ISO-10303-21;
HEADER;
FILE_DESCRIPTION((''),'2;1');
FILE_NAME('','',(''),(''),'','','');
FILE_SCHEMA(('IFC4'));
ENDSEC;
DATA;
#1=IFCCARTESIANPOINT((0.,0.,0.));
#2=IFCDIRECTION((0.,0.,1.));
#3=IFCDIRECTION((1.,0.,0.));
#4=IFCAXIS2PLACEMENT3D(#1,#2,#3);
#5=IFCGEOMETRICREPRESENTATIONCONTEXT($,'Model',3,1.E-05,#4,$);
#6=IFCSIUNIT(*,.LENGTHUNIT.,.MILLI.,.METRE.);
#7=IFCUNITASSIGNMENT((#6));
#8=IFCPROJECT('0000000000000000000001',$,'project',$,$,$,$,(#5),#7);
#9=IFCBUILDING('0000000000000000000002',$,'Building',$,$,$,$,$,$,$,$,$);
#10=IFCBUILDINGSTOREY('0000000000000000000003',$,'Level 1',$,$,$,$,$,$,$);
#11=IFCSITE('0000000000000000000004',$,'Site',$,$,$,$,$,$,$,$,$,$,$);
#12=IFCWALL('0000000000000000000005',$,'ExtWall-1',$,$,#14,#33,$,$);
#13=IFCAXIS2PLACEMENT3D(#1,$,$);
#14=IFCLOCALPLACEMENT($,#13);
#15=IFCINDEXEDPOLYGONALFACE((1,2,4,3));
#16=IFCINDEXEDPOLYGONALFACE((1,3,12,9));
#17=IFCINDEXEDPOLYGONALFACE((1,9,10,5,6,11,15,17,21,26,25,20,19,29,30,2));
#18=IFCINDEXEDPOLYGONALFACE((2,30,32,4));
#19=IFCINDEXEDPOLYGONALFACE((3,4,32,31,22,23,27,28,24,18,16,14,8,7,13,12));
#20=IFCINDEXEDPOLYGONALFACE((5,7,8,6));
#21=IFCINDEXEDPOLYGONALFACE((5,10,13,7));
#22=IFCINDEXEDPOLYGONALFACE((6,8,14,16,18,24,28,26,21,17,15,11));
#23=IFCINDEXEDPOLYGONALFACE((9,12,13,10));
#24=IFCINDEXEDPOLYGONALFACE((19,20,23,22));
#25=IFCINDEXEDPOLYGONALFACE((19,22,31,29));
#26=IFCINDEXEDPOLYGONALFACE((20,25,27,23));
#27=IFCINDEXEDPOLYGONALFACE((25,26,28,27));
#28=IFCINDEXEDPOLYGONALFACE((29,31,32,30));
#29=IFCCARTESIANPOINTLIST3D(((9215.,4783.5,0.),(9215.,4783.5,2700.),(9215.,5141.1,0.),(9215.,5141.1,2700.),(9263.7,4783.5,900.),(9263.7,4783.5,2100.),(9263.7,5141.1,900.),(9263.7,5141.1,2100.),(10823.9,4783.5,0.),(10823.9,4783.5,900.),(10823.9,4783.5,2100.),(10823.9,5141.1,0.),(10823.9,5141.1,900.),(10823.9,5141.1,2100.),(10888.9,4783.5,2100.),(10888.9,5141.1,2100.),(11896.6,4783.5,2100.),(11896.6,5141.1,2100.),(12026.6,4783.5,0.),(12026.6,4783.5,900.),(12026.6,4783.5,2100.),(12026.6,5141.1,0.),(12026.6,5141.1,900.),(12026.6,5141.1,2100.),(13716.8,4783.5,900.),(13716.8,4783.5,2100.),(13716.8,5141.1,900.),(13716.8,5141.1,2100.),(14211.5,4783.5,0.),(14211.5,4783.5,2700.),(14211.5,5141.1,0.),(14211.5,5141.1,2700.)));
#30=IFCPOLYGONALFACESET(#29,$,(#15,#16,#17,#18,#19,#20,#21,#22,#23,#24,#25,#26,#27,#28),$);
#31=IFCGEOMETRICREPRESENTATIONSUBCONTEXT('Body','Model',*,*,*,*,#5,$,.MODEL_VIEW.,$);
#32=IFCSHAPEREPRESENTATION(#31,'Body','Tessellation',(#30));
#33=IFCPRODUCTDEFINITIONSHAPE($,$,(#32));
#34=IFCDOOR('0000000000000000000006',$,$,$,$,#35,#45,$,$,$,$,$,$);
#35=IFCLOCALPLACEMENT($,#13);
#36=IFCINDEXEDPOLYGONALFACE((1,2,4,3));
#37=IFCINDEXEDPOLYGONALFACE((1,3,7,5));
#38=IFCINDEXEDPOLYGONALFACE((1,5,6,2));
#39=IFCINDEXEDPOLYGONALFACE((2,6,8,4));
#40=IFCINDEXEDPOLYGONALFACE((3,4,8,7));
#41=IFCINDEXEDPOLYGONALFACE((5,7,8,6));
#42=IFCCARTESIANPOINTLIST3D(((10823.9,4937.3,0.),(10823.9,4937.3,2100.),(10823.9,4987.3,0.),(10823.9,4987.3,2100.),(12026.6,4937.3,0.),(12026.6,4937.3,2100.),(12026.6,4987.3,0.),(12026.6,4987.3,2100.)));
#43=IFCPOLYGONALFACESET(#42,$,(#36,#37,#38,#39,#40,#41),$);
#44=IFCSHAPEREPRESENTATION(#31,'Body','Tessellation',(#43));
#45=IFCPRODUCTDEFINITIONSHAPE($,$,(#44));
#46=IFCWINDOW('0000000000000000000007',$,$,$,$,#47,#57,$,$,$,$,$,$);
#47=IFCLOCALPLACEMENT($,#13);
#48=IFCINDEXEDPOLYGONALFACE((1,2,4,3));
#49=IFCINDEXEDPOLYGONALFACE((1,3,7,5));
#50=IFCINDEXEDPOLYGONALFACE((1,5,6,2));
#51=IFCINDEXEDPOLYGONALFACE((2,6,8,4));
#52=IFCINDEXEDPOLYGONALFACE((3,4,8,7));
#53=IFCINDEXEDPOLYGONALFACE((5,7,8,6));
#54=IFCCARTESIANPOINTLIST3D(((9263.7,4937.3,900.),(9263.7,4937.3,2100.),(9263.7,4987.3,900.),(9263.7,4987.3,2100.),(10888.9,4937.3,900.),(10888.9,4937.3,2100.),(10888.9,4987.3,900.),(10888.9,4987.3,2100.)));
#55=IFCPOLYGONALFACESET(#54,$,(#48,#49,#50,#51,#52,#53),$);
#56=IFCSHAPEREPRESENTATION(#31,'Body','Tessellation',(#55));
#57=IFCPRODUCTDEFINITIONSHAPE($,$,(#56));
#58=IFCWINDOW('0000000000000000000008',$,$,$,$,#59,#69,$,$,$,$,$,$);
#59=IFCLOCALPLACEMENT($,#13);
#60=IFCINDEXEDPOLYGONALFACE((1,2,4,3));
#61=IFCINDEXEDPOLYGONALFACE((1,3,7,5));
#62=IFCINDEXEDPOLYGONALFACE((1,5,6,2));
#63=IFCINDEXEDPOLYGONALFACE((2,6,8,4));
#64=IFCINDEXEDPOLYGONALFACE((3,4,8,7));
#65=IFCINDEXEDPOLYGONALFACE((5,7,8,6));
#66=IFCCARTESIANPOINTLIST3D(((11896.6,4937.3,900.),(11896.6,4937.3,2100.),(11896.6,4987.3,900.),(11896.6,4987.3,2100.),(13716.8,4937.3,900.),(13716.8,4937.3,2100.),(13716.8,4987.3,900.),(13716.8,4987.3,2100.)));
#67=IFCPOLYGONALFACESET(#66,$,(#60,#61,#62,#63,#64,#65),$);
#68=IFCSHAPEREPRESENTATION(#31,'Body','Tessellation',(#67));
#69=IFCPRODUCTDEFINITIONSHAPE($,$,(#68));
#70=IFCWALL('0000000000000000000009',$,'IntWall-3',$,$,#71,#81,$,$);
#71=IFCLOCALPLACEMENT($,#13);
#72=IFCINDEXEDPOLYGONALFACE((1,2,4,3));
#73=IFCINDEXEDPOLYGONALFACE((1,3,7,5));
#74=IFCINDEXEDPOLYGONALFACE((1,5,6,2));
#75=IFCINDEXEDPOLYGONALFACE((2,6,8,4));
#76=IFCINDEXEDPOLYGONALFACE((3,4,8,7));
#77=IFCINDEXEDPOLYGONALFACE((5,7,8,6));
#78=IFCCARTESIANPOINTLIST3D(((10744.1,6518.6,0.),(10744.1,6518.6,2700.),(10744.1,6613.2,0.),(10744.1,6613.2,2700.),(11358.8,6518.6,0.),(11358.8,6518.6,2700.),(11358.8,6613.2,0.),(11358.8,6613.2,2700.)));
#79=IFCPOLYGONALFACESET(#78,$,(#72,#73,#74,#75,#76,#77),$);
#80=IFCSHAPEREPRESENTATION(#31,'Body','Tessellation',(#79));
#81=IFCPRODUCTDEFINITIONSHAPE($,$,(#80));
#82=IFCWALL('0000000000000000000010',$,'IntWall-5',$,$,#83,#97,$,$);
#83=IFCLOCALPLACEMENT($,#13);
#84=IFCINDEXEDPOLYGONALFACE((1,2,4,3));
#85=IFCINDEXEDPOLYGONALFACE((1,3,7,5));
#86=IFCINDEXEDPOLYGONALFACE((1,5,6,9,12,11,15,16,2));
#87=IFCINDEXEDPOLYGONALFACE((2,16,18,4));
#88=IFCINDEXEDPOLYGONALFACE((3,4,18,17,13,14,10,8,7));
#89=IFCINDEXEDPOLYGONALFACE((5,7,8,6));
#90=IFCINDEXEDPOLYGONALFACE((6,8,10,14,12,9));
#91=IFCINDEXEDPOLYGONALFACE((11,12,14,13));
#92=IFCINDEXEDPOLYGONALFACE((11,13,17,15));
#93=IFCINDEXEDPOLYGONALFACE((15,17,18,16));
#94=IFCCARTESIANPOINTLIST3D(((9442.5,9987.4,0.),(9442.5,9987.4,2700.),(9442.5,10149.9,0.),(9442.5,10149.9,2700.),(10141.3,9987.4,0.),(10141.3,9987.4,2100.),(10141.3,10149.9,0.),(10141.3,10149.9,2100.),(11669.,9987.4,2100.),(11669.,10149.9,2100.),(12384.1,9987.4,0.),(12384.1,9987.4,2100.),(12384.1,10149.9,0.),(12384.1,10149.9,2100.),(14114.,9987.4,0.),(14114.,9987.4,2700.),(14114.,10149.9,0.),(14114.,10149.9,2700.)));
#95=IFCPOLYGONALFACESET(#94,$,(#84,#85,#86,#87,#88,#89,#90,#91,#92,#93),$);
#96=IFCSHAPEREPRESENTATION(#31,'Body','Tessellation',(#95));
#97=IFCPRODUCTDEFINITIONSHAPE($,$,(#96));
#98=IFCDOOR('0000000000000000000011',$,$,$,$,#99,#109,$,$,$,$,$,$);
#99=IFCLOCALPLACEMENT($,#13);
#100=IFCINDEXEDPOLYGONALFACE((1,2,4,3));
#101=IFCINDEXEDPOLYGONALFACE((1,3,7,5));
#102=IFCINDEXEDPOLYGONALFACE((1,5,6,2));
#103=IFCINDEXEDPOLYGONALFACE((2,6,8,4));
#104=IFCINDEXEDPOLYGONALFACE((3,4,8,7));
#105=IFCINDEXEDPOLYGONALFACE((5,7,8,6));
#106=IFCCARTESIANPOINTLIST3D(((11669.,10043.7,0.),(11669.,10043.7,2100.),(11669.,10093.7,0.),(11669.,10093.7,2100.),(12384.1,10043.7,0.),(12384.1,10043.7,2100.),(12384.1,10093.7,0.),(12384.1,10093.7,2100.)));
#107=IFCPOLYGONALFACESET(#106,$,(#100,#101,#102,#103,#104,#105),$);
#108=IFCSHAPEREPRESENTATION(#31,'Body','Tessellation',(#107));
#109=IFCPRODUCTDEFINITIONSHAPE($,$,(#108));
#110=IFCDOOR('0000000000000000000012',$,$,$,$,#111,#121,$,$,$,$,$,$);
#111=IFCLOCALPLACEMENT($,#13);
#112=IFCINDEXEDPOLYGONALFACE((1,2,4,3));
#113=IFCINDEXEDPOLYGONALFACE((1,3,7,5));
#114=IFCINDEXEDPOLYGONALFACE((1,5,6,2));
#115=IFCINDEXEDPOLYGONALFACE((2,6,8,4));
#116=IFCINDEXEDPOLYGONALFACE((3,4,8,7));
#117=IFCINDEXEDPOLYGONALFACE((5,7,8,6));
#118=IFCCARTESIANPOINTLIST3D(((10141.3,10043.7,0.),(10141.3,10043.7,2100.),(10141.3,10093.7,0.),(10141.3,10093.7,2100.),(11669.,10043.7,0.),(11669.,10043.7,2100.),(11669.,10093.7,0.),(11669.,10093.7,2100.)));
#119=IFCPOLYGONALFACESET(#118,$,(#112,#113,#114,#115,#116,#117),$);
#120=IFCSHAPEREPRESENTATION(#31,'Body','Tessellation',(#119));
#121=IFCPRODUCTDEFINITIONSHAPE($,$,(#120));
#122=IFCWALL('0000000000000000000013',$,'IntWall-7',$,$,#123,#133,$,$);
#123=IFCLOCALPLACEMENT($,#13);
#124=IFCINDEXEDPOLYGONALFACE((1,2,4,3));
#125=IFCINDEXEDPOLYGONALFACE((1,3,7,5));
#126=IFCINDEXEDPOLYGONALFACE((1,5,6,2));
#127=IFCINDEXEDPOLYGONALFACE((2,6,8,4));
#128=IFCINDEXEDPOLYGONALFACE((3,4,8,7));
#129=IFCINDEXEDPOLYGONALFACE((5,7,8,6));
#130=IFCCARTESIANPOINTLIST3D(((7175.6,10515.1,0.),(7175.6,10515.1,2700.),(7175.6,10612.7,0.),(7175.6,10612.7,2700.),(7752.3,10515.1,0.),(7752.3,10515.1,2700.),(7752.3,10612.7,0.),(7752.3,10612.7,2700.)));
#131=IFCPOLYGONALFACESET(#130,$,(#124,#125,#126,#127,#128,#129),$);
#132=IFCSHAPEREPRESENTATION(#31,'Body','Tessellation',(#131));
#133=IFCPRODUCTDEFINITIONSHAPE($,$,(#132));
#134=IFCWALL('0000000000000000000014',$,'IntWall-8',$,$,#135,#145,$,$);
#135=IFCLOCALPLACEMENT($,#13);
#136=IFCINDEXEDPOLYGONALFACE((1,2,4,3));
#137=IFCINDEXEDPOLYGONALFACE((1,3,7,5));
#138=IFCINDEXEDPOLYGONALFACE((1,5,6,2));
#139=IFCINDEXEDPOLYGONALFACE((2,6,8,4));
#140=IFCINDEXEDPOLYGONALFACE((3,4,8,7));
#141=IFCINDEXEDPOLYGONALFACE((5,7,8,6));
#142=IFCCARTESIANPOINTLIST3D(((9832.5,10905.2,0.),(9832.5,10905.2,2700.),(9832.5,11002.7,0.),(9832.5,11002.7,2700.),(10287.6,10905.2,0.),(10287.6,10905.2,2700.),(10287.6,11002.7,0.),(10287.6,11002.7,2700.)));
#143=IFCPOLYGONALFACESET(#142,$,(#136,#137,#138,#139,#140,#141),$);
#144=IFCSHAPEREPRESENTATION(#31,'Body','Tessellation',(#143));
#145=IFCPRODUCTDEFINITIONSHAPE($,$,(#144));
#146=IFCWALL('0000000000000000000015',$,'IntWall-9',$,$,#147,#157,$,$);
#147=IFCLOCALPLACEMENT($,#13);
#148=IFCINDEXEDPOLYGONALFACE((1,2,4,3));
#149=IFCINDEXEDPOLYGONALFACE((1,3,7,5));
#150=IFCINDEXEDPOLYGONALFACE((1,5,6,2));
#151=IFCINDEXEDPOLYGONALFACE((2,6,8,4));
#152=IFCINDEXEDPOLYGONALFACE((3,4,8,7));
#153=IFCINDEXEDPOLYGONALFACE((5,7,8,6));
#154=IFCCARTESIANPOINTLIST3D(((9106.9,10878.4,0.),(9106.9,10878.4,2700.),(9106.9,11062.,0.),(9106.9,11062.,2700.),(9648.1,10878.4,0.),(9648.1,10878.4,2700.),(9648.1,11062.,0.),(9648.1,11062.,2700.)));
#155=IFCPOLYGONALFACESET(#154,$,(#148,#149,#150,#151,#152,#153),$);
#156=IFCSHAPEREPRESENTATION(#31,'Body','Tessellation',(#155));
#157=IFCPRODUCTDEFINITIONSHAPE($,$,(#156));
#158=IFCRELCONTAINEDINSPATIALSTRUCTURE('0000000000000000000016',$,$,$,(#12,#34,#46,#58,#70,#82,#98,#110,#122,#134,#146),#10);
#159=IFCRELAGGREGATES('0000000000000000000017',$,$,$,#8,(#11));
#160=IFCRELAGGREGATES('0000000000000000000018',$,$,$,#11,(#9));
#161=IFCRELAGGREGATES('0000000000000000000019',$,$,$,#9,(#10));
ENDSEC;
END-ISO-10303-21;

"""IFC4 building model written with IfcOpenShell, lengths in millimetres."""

from ifc_helpers import new_model, si_unit, frame, origin_with_axes, place, context, subcontext, project, spatial, indexed_curve, outline, extrude, element, fill, save


model = new_model("IFC4")

# Units and contexts
model_context = context("Model", 3, precision=1e-05, world=origin_with_axes())
body_context = subcontext(model_context, "Body", "Model", "MODEL_VIEW")
ifc_project = project(units=[si_unit("LENGTHUNIT", "METRE", prefix="MILLI")], contexts=[model_context])

# Site, building, storey
site = spatial("IfcSite", under=ifc_project, Name="Site")
building = spatial("IfcBuilding", under=site, Name="Building")
storey = spatial("IfcBuildingStorey", under=building, Name="Level 1")

# Wall, openings, door, windows
wall_1_placement = place(None, frame((9215.0, 4962.3, 0.0), z_axis=(0.0, 0.0, 1.0), x_axis=(1.0, 0.0, 0.0)))
wall_1 = element("IfcWall", 1, at=wall_1_placement, inside=storey, Name="ExtWall-1", context=body_context, shape_type="SweptSolid", body=[
    extrude(outline(indexed_curve([(0.0, 0.0), (0.0, 357.5), (4996.6, 357.5), (4996.6, 0.0), (0.0, 0.0)], self_intersect=False)), frame((0.0, -178.8, 0.0), z_axis=(0.0, 0.0, 1.0), x_axis=(1.0, 0.0, 0.0)), (0.0, 0.0, 1.0), 2700.0),
])
opening_1_placement = place(wall_1_placement, frame((1609.0, 0.0, 0.0), z_axis=(0.0, 0.0, 1.0), x_axis=(1.0, 0.0, 0.0)))
opening_1 = element("IfcOpeningElement", 2, at=opening_1_placement, cuts=wall_1, context=body_context, shape_type="SweptSolid", body=[
    extrude(outline(indexed_curve([(0.0, 0.0), (0.0, 457.5), (1202.7, 457.5), (1202.7, 0.0), (0.0, 0.0)], self_intersect=False)), frame((0.0, -228.8, 0.0), z_axis=(0.0, 0.0, 1.0), x_axis=(1.0, 0.0, 0.0)), (0.0, 0.0, 1.0), 2100.0),
])
opening_2_placement = place(wall_1_placement, frame((48.8, 0.0, 900.0), z_axis=(0.0, 0.0, 1.0), x_axis=(1.0, 0.0, 0.0)))
opening_2 = element("IfcOpeningElement", 3, at=opening_2_placement, cuts=wall_1, context=body_context, shape_type="SweptSolid", body=[
    extrude(outline(indexed_curve([(0.0, 0.0), (0.0, 457.5), (1625.2, 457.5), (1625.2, 0.0), (0.0, 0.0)], self_intersect=False)), frame((0.0, -228.8, 0.0), z_axis=(0.0, 0.0, 1.0), x_axis=(1.0, 0.0, 0.0)), (0.0, 0.0, 1.0), 1200.0),
])
opening_3_placement = place(wall_1_placement, frame((2681.6, 0.0, 900.0), z_axis=(0.0, 0.0, 1.0), x_axis=(1.0, 0.0, 0.0)))
opening_3 = element("IfcOpeningElement", 4, at=opening_3_placement, cuts=wall_1, context=body_context, shape_type="SweptSolid", body=[
    extrude(outline(indexed_curve([(0.0, 0.0), (0.0, 457.5), (1820.2, 457.5), (1820.2, 0.0), (0.0, 0.0)], self_intersect=False)), frame((0.0, -228.8, 0.0), z_axis=(0.0, 0.0, 1.0), x_axis=(1.0, 0.0, 0.0)), (0.0, 0.0, 1.0), 1200.0),
])
door_1_placement = place(opening_1_placement, origin_with_axes())
door_1 = element("IfcDoor", 5, at=door_1_placement, inside=storey, context=body_context, shape_type="SweptSolid", body=[
    extrude(outline(indexed_curve([(0.0, 0.0), (0.0, 50.0), (1202.7, 50.0), (1202.7, 0.0), (0.0, 0.0)], self_intersect=False)), frame((0.0, -25.0, 0.0), z_axis=(0.0, 0.0, 1.0), x_axis=(1.0, 0.0, 0.0)), (0.0, 0.0, 1.0), 2100.0),
])
fill(opening_1, door_1)
window_1_placement = place(opening_2_placement, origin_with_axes())
window_1 = element("IfcWindow", 6, at=window_1_placement, inside=storey, context=body_context, shape_type="SweptSolid", body=[
    extrude(outline(indexed_curve([(0.0, 0.0), (0.0, 50.0), (1625.2, 50.0), (1625.2, 0.0), (0.0, 0.0)], self_intersect=False)), frame((0.0, -25.0, 0.0), z_axis=(0.0, 0.0, 1.0), x_axis=(1.0, 0.0, 0.0)), (0.0, 0.0, 1.0), 1200.0),
])
fill(opening_2, window_1)
window_2_placement = place(opening_3_placement, origin_with_axes())
window_2 = element("IfcWindow", 7, at=window_2_placement, inside=storey, context=body_context, shape_type="SweptSolid", body=[
    extrude(outline(indexed_curve([(0.0, 0.0), (0.0, 50.0), (1820.2, 50.0), (1820.2, 0.0), (0.0, 0.0)], self_intersect=False)), frame((0.0, -25.0, 0.0), z_axis=(0.0, 0.0, 1.0), x_axis=(1.0, 0.0, 0.0)), (0.0, 0.0, 1.0), 1200.0),
])
fill(opening_3, window_2)

# Wall
wall_2_placement = place(None, frame((10744.1, 6565.9, 0.0), z_axis=(0.0, 0.0, 1.0), x_axis=(1.0, 0.0, 0.0)))
element("IfcWall", 8, at=wall_2_placement, inside=storey, Name="IntWall-3", context=body_context, shape_type="SweptSolid", body=[
    extrude(outline(indexed_curve([(0.0, 0.0), (0.0, 94.6), (614.7, 94.6), (614.7, 0.0), (0.0, 0.0)], self_intersect=False)), frame((0.0, -47.3, 0.0), z_axis=(0.0, 0.0, 1.0), x_axis=(1.0, 0.0, 0.0)), (0.0, 0.0, 1.0), 2700.0),
])

# Wall, openings, doors
wall_3_placement = place(None, frame((9442.5, 10068.7, 0.0), z_axis=(0.0, 0.0, 1.0), x_axis=(1.0, 0.0, 0.0)))
wall_3 = element("IfcWall", 9, at=wall_3_placement, inside=storey, Name="IntWall-5", context=body_context, shape_type="SweptSolid", body=[
    extrude(outline(indexed_curve([(0.0, 0.0), (0.0, 162.5), (4671.5, 162.5), (4671.5, 0.0), (0.0, 0.0)], self_intersect=False)), frame((0.0, -81.3, 0.0), z_axis=(0.0, 0.0, 1.0), x_axis=(1.0, 0.0, 0.0)), (0.0, 0.0, 1.0), 2700.0),
])
opening_4_placement = place(wall_3_placement, frame((2226.5, 0.0, 0.0), z_axis=(0.0, 0.0, 1.0), x_axis=(1.0, 0.0, 0.0)))
opening_4 = element("IfcOpeningElement", 10, at=opening_4_placement, cuts=wall_3, context=body_context, shape_type="SweptSolid", body=[
    extrude(outline(indexed_curve([(0.0, 0.0), (0.0, 262.5), (715.1, 262.5), (715.1, 0.0), (0.0, 0.0)], self_intersect=False)), frame((0.0, -131.3, 0.0), z_axis=(0.0, 0.0, 1.0), x_axis=(1.0, 0.0, 0.0)), (0.0, 0.0, 1.0), 2100.0),
])
opening_5_placement = place(wall_3_placement, frame((698.8, 0.0, 0.0), z_axis=(0.0, 0.0, 1.0), x_axis=(1.0, 0.0, 0.0)))
opening_5 = element("IfcOpeningElement", 11, at=opening_5_placement, cuts=wall_3, context=body_context, shape_type="SweptSolid", body=[
    extrude(outline(indexed_curve([(0.0, 0.0), (0.0, 262.5), (1527.7, 262.5), (1527.7, 0.0), (0.0, 0.0)], self_intersect=False)), frame((0.0, -131.3, 0.0), z_axis=(0.0, 0.0, 1.0), x_axis=(1.0, 0.0, 0.0)), (0.0, 0.0, 1.0), 2100.0),
])
door_2_placement = place(opening_4_placement, frame((0.0, 0.0, 0.0), z_axis=(0.0, 0.0, 1.0), x_axis=(1.0, 0.0, 0.0)))
door_2 = element("IfcDoor", 12, at=door_2_placement, inside=storey, context=body_context, shape_type="SweptSolid", body=[
    extrude(outline(indexed_curve([(0.0, 0.0), (0.0, 50.0), (715.1, 50.0), (715.1, 0.0), (0.0, 0.0)], self_intersect=False)), frame((0.0, -25.0, 0.0), z_axis=(0.0, 0.0, 1.0), x_axis=(1.0, 0.0, 0.0)), (0.0, 0.0, 1.0), 2100.0),
])
fill(opening_4, door_2)
door_3_placement = place(opening_5_placement, origin_with_axes())
door_3 = element("IfcDoor", 13, at=door_3_placement, inside=storey, context=body_context, shape_type="SweptSolid", body=[
    extrude(outline(indexed_curve([(0.0, 0.0), (0.0, 50.0), (1527.7, 50.0), (1527.7, 0.0), (0.0, 0.0)], self_intersect=False)), frame((0.0, -25.0, 0.0), z_axis=(0.0, 0.0, 1.0), x_axis=(1.0, 0.0, 0.0)), (0.0, 0.0, 1.0), 2100.0),
])
fill(opening_5, door_3)

# Walls
wall_4_placement = place(None, frame((7175.6, 10563.9, 0.0), z_axis=(0.0, 0.0, 1.0), x_axis=(1.0, 0.0, 0.0)))
element("IfcWall", 14, at=wall_4_placement, inside=storey, Name="IntWall-7", context=body_context, shape_type="SweptSolid", body=[
    extrude(outline(indexed_curve([(0.0, 0.0), (0.0, 97.5), (576.7, 97.5), (576.7, 0.0), (0.0, 0.0)], self_intersect=False)), frame((0.0, -48.8, 0.0), z_axis=(0.0, 0.0, 1.0), x_axis=(1.0, 0.0, 0.0)), (0.0, 0.0, 1.0), 2700.0),
])
wall_5_placement = place(None, frame((9832.5, 10953.9, 0.0), z_axis=(0.0, 0.0, 1.0), x_axis=(1.0, 0.0, 0.0)))
element("IfcWall", 15, at=wall_5_placement, inside=storey, Name="IntWall-8", context=body_context, shape_type="SweptSolid", body=[
    extrude(outline(indexed_curve([(0.0, 0.0), (0.0, 97.5), (455.1, 97.5), (455.1, 0.0), (0.0, 0.0)], self_intersect=False)), frame((0.0, -48.8, 0.0), z_axis=(0.0, 0.0, 1.0), x_axis=(1.0, 0.0, 0.0)), (0.0, 0.0, 1.0), 2700.0),
])
wall_6_placement = place(None, frame((9106.9, 10970.2, 0.0), z_axis=(0.0, 0.0, 1.0), x_axis=(1.0, 0.0, 0.0)))
element("IfcWall", 16, at=wall_6_placement, inside=storey, Name="IntWall-9", context=body_context, shape_type="SweptSolid", body=[
    extrude(outline(indexed_curve([(0.0, 0.0), (0.0, 183.6), (541.2, 183.6), (541.2, 0.0), (0.0, 0.0)], self_intersect=False)), frame((0.0, -91.8, 0.0), z_axis=(0.0, 0.0, 1.0), x_axis=(1.0, 0.0, 0.0)), (0.0, 0.0, 1.0), 2700.0),
])

save(model, "model.ifc")
